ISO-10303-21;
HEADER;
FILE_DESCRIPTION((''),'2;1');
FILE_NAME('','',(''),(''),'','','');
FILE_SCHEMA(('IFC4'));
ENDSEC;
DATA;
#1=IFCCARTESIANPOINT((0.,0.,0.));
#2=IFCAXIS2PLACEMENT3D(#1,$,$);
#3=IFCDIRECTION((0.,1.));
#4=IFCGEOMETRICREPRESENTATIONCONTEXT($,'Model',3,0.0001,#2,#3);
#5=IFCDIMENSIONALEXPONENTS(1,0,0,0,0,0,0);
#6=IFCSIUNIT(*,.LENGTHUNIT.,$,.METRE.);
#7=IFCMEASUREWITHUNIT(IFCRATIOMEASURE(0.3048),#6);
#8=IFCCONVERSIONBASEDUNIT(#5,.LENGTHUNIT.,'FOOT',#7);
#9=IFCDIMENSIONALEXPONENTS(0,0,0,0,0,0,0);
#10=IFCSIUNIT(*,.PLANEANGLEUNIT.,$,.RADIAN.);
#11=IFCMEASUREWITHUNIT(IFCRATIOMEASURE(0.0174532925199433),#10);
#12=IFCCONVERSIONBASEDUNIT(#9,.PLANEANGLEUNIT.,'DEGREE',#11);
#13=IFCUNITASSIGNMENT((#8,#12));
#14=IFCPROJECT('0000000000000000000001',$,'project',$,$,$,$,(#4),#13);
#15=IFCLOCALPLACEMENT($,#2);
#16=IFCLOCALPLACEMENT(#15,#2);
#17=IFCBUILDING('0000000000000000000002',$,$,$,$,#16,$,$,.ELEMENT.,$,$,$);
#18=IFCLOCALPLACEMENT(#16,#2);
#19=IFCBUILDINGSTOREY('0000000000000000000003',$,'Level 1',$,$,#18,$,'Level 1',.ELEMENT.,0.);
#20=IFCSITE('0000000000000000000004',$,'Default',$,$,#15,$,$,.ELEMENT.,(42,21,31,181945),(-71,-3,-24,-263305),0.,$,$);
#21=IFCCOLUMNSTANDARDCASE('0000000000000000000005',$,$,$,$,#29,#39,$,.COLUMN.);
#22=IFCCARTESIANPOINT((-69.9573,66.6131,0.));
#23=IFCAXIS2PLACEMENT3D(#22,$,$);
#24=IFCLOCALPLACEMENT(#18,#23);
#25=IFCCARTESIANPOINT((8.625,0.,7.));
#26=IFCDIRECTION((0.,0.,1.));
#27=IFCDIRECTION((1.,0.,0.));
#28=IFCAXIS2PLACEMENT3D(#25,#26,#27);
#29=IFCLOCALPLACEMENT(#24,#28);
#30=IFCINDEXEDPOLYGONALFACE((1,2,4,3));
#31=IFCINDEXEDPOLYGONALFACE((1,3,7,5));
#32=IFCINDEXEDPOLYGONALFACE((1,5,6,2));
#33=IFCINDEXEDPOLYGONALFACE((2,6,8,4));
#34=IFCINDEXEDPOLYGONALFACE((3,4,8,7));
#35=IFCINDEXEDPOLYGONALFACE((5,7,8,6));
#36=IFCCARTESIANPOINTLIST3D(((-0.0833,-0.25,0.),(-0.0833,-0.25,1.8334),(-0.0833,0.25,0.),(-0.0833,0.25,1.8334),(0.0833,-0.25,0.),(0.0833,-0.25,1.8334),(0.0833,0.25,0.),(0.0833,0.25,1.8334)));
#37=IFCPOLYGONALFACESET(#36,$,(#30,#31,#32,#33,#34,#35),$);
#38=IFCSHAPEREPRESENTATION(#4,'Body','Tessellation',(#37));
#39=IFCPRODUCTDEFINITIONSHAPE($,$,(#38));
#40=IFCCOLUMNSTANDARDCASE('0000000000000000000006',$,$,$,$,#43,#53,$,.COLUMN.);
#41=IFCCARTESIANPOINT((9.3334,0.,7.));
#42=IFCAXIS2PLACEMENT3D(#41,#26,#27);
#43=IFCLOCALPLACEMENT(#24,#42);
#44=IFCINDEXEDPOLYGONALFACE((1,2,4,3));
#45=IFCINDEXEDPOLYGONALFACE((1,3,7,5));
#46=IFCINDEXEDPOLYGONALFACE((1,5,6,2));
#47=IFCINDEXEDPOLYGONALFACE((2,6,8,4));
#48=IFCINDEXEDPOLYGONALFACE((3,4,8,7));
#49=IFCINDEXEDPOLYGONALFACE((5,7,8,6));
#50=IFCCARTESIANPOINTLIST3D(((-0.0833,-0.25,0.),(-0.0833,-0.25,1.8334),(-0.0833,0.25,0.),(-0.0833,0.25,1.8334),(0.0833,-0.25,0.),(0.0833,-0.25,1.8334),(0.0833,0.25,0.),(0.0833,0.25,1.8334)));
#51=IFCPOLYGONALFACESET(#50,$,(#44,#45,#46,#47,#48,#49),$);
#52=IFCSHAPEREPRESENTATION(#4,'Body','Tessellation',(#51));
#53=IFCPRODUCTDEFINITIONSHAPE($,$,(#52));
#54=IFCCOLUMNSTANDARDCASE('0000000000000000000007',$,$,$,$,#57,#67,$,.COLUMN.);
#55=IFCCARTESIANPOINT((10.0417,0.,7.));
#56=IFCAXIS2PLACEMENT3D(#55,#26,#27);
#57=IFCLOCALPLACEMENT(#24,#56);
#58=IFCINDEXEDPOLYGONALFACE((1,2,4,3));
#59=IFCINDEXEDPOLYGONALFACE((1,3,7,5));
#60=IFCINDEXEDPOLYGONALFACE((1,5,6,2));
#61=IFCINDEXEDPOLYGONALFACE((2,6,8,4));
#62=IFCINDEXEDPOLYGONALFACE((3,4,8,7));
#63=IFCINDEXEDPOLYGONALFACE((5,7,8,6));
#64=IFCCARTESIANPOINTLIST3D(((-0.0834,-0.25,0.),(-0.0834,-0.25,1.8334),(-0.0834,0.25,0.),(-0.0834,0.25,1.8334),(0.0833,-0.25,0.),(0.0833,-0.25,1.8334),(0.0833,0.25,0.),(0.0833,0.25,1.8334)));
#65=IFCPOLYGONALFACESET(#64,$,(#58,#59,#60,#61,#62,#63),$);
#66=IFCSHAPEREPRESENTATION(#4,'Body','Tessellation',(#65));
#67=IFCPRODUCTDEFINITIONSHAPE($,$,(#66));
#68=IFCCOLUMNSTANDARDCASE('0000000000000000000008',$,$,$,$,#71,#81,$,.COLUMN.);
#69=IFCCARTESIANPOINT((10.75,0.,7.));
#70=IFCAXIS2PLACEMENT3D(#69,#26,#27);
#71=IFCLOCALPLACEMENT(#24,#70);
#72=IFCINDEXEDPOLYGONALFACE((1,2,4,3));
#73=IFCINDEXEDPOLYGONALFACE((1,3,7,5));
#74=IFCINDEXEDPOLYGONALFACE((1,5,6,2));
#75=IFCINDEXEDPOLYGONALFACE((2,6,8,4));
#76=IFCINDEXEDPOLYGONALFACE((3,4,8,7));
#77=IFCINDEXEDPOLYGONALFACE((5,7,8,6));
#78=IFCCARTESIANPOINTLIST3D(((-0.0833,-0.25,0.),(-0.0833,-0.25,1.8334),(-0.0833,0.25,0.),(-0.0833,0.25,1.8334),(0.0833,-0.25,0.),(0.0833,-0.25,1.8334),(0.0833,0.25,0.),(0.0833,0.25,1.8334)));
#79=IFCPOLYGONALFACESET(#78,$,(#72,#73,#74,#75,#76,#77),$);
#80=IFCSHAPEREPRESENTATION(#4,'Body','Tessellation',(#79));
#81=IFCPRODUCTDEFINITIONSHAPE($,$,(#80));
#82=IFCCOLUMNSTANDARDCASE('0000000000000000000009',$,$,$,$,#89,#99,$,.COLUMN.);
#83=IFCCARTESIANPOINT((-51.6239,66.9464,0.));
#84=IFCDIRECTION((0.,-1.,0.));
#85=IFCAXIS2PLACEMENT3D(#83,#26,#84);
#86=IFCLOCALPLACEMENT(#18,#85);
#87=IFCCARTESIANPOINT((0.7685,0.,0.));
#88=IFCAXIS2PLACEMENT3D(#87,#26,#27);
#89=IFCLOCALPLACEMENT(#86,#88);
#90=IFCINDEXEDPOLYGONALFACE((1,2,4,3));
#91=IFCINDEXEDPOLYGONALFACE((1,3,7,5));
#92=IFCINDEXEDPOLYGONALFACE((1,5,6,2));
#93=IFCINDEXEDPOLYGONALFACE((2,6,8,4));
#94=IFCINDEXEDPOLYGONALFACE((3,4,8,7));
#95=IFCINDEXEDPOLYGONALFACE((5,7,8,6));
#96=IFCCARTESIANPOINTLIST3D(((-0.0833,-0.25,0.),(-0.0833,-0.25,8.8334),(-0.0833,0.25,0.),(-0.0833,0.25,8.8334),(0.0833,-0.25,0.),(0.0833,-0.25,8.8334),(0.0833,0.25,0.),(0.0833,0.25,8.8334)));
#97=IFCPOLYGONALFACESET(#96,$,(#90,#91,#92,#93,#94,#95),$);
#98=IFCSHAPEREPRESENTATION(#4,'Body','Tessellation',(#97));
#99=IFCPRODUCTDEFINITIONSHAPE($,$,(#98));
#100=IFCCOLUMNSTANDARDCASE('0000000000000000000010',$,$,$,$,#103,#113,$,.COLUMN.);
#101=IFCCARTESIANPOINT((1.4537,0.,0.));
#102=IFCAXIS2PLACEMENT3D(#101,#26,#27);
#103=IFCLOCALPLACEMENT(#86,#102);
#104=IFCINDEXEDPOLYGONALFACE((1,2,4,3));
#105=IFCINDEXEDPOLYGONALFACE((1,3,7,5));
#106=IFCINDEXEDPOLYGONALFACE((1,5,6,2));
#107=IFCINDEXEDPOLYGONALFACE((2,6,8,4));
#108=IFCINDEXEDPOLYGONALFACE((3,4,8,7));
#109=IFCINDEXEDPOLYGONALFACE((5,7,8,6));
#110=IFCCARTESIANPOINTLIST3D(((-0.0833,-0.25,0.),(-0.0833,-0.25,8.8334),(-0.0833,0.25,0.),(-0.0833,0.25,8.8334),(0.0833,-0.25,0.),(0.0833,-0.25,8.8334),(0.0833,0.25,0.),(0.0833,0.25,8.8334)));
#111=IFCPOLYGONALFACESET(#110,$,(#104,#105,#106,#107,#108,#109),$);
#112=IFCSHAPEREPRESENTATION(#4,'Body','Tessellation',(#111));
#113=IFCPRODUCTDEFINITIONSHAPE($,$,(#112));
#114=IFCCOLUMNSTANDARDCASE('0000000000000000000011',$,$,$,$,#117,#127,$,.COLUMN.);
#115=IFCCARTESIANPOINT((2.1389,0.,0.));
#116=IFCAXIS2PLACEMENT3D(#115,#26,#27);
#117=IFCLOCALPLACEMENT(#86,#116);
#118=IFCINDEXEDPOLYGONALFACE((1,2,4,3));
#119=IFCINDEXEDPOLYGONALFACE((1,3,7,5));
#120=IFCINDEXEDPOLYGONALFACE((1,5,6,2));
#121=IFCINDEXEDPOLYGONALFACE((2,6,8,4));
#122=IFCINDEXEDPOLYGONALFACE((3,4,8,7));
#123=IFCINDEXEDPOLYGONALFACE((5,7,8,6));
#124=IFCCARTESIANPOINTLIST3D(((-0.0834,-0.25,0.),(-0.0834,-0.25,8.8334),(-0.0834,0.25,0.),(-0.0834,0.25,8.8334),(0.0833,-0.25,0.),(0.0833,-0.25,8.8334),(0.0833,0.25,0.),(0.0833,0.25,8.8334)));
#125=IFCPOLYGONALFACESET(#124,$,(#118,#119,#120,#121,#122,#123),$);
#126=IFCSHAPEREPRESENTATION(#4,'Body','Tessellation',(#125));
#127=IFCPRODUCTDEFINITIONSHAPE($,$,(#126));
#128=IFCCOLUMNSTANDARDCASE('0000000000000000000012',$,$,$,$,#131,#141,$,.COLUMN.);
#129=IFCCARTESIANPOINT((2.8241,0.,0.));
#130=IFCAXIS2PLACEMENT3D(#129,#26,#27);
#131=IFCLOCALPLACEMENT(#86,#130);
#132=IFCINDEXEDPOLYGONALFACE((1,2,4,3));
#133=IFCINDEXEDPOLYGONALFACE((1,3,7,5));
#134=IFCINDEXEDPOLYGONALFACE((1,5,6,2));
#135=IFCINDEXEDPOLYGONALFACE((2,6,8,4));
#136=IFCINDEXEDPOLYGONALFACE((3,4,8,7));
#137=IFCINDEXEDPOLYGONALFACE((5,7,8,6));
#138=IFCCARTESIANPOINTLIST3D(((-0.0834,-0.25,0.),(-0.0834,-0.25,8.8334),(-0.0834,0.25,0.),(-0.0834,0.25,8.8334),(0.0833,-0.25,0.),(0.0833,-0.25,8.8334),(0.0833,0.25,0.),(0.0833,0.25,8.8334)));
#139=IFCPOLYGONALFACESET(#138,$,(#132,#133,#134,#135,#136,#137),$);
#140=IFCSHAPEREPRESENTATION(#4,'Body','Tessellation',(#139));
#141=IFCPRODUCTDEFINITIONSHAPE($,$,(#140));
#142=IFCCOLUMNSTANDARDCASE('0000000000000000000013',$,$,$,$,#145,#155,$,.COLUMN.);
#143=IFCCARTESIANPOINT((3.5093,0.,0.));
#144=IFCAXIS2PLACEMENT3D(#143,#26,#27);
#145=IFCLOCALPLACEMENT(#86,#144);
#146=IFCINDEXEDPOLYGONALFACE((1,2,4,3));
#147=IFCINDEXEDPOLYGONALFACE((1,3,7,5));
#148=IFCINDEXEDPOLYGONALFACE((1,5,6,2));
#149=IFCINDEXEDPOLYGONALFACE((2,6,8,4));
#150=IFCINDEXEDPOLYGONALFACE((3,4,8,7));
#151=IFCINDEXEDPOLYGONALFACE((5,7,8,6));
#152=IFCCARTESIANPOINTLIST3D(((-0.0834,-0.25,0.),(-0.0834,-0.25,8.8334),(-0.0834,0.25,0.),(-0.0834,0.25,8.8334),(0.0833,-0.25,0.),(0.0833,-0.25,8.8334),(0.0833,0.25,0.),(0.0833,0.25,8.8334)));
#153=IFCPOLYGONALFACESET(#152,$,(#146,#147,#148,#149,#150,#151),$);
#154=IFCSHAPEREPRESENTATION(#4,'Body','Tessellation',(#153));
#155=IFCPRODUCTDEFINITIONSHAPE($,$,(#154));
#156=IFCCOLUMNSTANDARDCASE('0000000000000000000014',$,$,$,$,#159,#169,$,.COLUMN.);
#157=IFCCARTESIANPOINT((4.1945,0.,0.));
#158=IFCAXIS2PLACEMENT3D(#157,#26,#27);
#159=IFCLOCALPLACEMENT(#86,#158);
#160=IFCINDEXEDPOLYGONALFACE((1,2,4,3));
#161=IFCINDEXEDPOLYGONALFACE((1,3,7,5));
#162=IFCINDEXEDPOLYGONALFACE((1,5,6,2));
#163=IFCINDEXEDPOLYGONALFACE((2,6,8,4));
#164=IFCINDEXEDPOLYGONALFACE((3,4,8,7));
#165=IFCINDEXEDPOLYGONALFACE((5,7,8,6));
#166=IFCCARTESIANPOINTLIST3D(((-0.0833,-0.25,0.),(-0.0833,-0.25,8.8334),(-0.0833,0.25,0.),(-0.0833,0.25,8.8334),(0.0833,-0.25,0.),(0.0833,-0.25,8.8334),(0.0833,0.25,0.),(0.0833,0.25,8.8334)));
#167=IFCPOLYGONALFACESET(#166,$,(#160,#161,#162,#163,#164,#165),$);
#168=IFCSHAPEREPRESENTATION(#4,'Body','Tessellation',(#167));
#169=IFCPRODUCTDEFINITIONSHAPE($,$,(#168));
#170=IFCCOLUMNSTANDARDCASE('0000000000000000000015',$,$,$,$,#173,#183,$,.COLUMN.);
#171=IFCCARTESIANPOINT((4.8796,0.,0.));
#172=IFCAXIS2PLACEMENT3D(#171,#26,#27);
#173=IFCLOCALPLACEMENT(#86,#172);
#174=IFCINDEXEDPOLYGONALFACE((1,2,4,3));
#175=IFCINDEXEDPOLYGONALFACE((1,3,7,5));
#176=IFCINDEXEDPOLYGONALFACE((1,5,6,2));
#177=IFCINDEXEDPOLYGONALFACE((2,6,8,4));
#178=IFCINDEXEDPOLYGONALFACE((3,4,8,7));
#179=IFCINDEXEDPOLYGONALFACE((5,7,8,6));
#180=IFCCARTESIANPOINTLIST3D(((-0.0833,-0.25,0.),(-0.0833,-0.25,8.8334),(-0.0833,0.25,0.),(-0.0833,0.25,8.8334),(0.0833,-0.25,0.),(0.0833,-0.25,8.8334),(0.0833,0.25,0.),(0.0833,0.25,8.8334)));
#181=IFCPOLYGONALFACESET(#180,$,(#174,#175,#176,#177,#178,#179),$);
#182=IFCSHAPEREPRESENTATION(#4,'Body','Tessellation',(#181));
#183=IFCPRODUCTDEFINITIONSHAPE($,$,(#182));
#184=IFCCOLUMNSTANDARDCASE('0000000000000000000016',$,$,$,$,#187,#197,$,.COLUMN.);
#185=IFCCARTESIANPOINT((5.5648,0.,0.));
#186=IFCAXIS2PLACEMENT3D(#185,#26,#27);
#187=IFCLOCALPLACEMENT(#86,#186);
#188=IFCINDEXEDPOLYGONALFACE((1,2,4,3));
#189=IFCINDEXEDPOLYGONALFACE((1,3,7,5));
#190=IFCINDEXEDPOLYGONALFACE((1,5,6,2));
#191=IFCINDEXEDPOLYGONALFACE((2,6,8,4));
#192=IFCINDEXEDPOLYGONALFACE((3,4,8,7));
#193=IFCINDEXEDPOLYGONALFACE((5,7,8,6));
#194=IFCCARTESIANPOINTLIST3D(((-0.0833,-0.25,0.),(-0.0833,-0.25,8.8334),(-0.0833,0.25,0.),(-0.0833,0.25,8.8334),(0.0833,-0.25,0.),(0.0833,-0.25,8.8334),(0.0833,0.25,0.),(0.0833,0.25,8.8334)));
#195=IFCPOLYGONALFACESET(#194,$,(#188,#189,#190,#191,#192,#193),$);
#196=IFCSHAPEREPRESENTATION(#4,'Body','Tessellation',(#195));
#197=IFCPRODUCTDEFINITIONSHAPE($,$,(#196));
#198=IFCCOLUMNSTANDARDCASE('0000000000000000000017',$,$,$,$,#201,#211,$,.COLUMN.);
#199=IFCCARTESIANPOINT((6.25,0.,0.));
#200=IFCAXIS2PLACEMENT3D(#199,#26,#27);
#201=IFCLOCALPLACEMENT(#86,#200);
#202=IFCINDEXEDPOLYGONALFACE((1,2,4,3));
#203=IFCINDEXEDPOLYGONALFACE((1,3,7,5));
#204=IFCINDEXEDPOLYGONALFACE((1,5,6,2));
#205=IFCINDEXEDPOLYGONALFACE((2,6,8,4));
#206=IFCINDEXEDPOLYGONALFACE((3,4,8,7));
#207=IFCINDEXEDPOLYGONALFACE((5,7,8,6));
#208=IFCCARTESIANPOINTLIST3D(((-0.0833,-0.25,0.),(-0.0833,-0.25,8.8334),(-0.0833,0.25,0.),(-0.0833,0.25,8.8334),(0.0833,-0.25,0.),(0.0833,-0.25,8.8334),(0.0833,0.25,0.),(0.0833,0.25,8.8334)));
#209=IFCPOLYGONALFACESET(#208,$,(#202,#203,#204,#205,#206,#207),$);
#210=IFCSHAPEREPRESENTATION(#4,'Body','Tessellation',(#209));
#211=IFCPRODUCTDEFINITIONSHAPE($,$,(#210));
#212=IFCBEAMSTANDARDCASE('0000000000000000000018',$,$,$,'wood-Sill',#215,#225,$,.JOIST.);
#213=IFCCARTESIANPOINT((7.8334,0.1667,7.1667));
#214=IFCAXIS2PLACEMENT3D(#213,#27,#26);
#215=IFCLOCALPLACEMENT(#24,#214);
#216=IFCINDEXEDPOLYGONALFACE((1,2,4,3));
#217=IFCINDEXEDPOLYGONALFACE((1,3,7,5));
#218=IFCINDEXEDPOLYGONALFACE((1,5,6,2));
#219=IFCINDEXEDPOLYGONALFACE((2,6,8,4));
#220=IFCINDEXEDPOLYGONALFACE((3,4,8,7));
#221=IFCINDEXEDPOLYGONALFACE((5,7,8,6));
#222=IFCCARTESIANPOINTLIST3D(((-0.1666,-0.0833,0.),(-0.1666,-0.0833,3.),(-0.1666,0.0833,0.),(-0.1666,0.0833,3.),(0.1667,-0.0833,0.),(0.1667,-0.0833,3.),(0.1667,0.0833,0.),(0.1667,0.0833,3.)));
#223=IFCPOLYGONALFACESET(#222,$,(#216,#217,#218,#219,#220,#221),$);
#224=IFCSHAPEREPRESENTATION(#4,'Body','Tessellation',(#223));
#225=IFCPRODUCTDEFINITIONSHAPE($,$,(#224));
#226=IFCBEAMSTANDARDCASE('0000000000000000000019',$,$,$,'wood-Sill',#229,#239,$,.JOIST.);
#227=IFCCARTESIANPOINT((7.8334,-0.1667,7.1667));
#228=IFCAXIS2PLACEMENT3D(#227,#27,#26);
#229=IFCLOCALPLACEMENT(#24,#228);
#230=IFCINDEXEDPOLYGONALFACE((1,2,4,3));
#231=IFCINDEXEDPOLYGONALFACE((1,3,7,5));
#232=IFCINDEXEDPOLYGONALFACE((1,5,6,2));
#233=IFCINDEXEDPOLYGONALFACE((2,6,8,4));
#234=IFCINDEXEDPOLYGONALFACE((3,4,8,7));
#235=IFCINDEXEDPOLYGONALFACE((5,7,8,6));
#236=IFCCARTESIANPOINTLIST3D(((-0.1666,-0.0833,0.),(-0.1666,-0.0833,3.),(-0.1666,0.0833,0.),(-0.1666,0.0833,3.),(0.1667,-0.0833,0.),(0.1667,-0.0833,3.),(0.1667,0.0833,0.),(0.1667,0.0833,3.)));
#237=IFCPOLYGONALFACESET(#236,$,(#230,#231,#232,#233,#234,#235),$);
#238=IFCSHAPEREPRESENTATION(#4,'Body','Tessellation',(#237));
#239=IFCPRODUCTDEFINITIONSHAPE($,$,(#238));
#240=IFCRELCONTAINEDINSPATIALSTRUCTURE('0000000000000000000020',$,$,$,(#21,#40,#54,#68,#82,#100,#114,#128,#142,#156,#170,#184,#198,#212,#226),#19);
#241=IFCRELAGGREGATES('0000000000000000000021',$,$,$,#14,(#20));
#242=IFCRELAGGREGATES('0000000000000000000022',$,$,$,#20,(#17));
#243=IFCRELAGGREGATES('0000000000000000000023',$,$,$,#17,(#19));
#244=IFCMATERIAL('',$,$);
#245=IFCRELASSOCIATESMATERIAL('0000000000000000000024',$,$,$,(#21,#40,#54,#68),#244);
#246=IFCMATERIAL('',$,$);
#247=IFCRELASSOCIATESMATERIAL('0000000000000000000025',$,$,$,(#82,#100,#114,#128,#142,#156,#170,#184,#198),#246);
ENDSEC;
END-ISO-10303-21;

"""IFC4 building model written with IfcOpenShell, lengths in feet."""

from ifc_helpers import new_model, entity, si_unit, converted_unit, direction, frame, origin, origin_with_axes, place, context, project, spatial, rectangle, extrude, material, element, save


model = new_model("IFC4")

# Units and contexts
model_context = context("Model", 3, precision=0.0001, world=origin(), true_north=direction((0.0, 1.0)))
ifc_project = project(units=[converted_unit("LENGTHUNIT", "FOOT", entity("IfcRatioMeasure", 0.3048), si_unit("LENGTHUNIT", "METRE"), dimensions=[1, 0, 0, 0, 0, 0, 0]), converted_unit("PLANEANGLEUNIT", "DEGREE", entity("IfcRatioMeasure", 0.0174532925199433), si_unit("PLANEANGLEUNIT", "RADIAN"), dimensions=[0, 0, 0, 0, 0, 0, 0])], contexts=[model_context])

# Site, building, storey
site_placement = place(None, origin())
site = spatial("IfcSite", under=ifc_project, at=site_placement, Name="Default", CompositionType="ELEMENT", RefLatitude=(42, 21, 31, 181945), RefLongitude=(-71, -3, -24, -263305), RefElevation=0.0)
building_placement = place(site_placement, origin())
building = spatial("IfcBuilding", under=site, at=building_placement, CompositionType="ELEMENT")
storey_placement = place(building_placement, origin())
storey = spatial("IfcBuildingStorey", under=building, at=storey_placement, Name="Level 1", LongName="Level 1", CompositionType="ELEMENT", Elevation=0.0)

# Columns
ifc_material_1 = material(Name="")
placement_1 = place(storey_placement, frame((-69.9573, 66.6131, 0.0)))
ifc_material_2 = material(Name="")
for number, where, z_axis, x_axis in (
    (1, (8.625, 0.0, 7.0), (0.0, 0.0, 1.0), (1.0, 0.0, 0.0)),
    (2, (9.3334, 0.0, 7.0), (0.0, 0.0, 1.0), (1.0, 0.0, 0.0)),
    (3, (10.0417, 0.0, 7.0), (0.0, 0.0, 1.0), (1.0, 0.0, 0.0)),
    (4, (10.75, 0.0, 7.0), (0.0, 0.0, 1.0), (1.0, 0.0, 0.0)),
):
    element("IfcColumnStandardCase", number, at=place(placement_1, frame(where, z_axis=z_axis, x_axis=x_axis)), inside=storey, material=ifc_material_2, PredefinedType="COLUMN", context=model_context, shape_type="SweptSolid", body=[
        extrude(rectangle(XDim=0.1667, YDim=0.5), origin(), (0.0, 0.0, 1.0), 1.8334),
    ])
placement_2 = place(storey_placement, frame((-51.6239, 66.9464, 0.0), z_axis=(0.0, 0.0, 1.0), x_axis=(0.0, -1.0, 0.0)))
for number, where, z_axis, x_axis in (
    (5, (0.7685, 0.0, 0.0), (0.0, 0.0, 1.0), (1.0, 0.0, 0.0)),
    (6, (1.4537, 0.0, 0.0), (0.0, 0.0, 1.0), (1.0, 0.0, 0.0)),
    (7, (2.1389, 0.0, 0.0), (0.0, 0.0, 1.0), (1.0, 0.0, 0.0)),
    (8, (2.8241, 0.0, 0.0), (0.0, 0.0, 1.0), (1.0, 0.0, 0.0)),
    (9, (3.5093, 0.0, 0.0), (0.0, 0.0, 1.0), (1.0, 0.0, 0.0)),
    (10, (4.1945, 0.0, 0.0), (0.0, 0.0, 1.0), (1.0, 0.0, 0.0)),
    (11, (4.8796, 0.0, 0.0), (0.0, 0.0, 1.0), (1.0, 0.0, 0.0)),
    (12, (5.5648, 0.0, 0.0), (0.0, 0.0, 1.0), (1.0, 0.0, 0.0)),
    (13, (6.25, 0.0, 0.0), (0.0, 0.0, 1.0), (1.0, 0.0, 0.0)),
):
    element("IfcColumnStandardCase", number, at=place(placement_2, frame(where, z_axis=z_axis, x_axis=x_axis)), inside=storey, material=ifc_material_1, PredefinedType="COLUMN", context=model_context, shape_type="SweptSolid", body=[
        extrude(rectangle(XDim=0.1667, YDim=0.5), origin(), (0.0, 0.0, 1.0), 8.8334),
    ])

# Beams
for number, where, z_axis, x_axis in (
    (14, (7.8334, 0.1667, 7.1667), (1.0, 0.0, 0.0), (0.0, 0.0, 1.0)),
    (15, (7.8334, -0.1667, 7.1667), (1.0, 0.0, 0.0), (0.0, 0.0, 1.0)),
):
    element("IfcBeamStandardCase", number, at=place(placement_1, frame(where, z_axis=z_axis, x_axis=x_axis)), inside=storey, ObjectType="wood-Sill", PredefinedType="JOIST", context=model_context, shape_type="SweptSolid", body=[
        extrude(rectangle(XDim=0.3333, YDim=0.1667), origin_with_axes(), (0.0, 0.0, 1.0), 3.0),
    ])

save(model, "model.ifc")
